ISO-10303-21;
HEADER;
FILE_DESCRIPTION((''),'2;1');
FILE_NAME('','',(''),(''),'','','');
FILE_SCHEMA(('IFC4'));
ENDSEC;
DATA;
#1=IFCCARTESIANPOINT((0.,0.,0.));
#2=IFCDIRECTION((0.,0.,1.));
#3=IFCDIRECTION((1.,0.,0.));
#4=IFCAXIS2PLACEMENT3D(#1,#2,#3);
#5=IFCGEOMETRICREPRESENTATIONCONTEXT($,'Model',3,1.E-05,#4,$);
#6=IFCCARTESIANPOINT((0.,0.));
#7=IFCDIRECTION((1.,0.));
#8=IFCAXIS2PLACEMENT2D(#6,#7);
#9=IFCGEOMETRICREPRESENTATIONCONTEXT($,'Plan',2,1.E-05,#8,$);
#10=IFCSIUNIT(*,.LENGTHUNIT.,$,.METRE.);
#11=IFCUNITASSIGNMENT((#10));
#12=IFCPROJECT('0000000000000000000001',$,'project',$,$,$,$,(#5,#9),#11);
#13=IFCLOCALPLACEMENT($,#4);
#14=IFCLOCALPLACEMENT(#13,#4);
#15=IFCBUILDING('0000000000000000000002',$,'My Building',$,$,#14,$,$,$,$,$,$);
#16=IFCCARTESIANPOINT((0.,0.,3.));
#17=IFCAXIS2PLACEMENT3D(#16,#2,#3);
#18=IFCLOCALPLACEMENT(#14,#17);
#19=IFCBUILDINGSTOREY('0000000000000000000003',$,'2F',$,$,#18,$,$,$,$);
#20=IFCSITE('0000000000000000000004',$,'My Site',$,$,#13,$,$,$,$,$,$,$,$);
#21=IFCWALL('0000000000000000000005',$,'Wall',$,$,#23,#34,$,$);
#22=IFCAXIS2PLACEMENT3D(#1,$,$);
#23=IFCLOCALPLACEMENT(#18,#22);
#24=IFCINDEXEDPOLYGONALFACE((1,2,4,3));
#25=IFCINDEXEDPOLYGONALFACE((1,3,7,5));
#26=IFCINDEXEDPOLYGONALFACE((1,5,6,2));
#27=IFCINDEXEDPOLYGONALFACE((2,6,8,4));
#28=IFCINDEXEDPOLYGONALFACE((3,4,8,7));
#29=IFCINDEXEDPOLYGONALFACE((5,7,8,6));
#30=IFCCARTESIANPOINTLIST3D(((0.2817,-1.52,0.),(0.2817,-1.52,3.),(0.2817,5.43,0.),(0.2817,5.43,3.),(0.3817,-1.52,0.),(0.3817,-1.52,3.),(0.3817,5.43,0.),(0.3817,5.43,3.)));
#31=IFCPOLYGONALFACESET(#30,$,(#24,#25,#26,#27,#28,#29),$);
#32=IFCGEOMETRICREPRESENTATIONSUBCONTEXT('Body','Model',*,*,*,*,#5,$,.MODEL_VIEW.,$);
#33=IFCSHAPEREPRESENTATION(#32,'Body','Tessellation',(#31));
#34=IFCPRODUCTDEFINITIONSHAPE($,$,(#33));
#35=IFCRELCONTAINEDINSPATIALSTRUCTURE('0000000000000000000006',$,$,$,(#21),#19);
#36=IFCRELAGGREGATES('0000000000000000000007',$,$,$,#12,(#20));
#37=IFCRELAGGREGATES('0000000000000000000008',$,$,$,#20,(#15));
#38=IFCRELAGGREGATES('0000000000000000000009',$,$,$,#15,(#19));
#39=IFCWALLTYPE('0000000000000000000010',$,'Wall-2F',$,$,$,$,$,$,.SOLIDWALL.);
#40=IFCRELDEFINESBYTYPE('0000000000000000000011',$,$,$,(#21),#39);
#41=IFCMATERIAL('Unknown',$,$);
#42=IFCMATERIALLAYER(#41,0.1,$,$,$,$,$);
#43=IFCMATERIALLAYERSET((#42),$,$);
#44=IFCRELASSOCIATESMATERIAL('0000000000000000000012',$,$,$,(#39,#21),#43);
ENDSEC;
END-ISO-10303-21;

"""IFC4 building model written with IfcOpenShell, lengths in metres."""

from ifc_helpers import new_model, si_unit, frame, origin_with_axes, origin_2d_with_axis, place, context, subcontext, project, spatial, line, indexed_curve, outline, extrude, material, layer, layer_set, layer_usage, type_object, element, save


model = new_model("IFC4")

# Units and contexts
model_context = context("Model", 3, precision=1e-05, world=origin_with_axes())
plan_context = context("Plan", 2, precision=1e-05, world=origin_2d_with_axis())
body_context_1 = subcontext(model_context, "Body", "Model", "MODEL_VIEW")
ifc_project = project(units=[si_unit("LENGTHUNIT", "METRE")], contexts=[model_context, plan_context])

# Site, building, storey
site_placement = place(None, origin_with_axes())
site = spatial("IfcSite", under=ifc_project, at=site_placement, Name="My Site")
building_placement = place(site_placement, origin_with_axes())
building = spatial("IfcBuilding", under=site, at=building_placement, Name="My Building")
storey_placement = place(building_placement, frame((0.0, 0.0, 3.0), z_axis=(0.0, 0.0, 1.0), x_axis=(1.0, 0.0, 0.0)))
storey = spatial("IfcBuildingStorey", under=building, at=storey_placement, Name="2F")

# Shared definitions
ifc_material = material(Name="Unknown")

# Shared definitions
ifc_layer_1 = layer(ifc_material, 0.1)
ifc_layer_set_1 = layer_set([ifc_layer_1])
wall_type_1 = type_object("IfcWallType", Name="Wall-2F", PredefinedType="SOLIDWALL", material=ifc_layer_set_1)

# Wall
ifc_layer_usage_1 = layer_usage(ifc_layer_set_1, "AXIS2", "POSITIVE", 0.0)
wall_1_placement = place(storey_placement, frame((0.3817, -1.52, 0.0), z_axis=(0.0, 0.0, 1.0), x_axis=(0.0, 1.0, 0.0)))
element("IfcWall", 1, at=wall_1_placement, inside=storey, type_object=wall_type_1, material=ifc_layer_usage_1, Name="Wall", context=body_context_1, shape_type="SweptSolid", body=[
    extrude(outline(indexed_curve([(0.0, 0.0), (0.0, 0.1), (6.95, 0.1), (6.95, 0.0)], segments=[line(1, 2, 3, 4, 1)])), origin_with_axes(), (0.0, 0.0, 1.0), 3.0),
])

save(model, "model.ifc")
